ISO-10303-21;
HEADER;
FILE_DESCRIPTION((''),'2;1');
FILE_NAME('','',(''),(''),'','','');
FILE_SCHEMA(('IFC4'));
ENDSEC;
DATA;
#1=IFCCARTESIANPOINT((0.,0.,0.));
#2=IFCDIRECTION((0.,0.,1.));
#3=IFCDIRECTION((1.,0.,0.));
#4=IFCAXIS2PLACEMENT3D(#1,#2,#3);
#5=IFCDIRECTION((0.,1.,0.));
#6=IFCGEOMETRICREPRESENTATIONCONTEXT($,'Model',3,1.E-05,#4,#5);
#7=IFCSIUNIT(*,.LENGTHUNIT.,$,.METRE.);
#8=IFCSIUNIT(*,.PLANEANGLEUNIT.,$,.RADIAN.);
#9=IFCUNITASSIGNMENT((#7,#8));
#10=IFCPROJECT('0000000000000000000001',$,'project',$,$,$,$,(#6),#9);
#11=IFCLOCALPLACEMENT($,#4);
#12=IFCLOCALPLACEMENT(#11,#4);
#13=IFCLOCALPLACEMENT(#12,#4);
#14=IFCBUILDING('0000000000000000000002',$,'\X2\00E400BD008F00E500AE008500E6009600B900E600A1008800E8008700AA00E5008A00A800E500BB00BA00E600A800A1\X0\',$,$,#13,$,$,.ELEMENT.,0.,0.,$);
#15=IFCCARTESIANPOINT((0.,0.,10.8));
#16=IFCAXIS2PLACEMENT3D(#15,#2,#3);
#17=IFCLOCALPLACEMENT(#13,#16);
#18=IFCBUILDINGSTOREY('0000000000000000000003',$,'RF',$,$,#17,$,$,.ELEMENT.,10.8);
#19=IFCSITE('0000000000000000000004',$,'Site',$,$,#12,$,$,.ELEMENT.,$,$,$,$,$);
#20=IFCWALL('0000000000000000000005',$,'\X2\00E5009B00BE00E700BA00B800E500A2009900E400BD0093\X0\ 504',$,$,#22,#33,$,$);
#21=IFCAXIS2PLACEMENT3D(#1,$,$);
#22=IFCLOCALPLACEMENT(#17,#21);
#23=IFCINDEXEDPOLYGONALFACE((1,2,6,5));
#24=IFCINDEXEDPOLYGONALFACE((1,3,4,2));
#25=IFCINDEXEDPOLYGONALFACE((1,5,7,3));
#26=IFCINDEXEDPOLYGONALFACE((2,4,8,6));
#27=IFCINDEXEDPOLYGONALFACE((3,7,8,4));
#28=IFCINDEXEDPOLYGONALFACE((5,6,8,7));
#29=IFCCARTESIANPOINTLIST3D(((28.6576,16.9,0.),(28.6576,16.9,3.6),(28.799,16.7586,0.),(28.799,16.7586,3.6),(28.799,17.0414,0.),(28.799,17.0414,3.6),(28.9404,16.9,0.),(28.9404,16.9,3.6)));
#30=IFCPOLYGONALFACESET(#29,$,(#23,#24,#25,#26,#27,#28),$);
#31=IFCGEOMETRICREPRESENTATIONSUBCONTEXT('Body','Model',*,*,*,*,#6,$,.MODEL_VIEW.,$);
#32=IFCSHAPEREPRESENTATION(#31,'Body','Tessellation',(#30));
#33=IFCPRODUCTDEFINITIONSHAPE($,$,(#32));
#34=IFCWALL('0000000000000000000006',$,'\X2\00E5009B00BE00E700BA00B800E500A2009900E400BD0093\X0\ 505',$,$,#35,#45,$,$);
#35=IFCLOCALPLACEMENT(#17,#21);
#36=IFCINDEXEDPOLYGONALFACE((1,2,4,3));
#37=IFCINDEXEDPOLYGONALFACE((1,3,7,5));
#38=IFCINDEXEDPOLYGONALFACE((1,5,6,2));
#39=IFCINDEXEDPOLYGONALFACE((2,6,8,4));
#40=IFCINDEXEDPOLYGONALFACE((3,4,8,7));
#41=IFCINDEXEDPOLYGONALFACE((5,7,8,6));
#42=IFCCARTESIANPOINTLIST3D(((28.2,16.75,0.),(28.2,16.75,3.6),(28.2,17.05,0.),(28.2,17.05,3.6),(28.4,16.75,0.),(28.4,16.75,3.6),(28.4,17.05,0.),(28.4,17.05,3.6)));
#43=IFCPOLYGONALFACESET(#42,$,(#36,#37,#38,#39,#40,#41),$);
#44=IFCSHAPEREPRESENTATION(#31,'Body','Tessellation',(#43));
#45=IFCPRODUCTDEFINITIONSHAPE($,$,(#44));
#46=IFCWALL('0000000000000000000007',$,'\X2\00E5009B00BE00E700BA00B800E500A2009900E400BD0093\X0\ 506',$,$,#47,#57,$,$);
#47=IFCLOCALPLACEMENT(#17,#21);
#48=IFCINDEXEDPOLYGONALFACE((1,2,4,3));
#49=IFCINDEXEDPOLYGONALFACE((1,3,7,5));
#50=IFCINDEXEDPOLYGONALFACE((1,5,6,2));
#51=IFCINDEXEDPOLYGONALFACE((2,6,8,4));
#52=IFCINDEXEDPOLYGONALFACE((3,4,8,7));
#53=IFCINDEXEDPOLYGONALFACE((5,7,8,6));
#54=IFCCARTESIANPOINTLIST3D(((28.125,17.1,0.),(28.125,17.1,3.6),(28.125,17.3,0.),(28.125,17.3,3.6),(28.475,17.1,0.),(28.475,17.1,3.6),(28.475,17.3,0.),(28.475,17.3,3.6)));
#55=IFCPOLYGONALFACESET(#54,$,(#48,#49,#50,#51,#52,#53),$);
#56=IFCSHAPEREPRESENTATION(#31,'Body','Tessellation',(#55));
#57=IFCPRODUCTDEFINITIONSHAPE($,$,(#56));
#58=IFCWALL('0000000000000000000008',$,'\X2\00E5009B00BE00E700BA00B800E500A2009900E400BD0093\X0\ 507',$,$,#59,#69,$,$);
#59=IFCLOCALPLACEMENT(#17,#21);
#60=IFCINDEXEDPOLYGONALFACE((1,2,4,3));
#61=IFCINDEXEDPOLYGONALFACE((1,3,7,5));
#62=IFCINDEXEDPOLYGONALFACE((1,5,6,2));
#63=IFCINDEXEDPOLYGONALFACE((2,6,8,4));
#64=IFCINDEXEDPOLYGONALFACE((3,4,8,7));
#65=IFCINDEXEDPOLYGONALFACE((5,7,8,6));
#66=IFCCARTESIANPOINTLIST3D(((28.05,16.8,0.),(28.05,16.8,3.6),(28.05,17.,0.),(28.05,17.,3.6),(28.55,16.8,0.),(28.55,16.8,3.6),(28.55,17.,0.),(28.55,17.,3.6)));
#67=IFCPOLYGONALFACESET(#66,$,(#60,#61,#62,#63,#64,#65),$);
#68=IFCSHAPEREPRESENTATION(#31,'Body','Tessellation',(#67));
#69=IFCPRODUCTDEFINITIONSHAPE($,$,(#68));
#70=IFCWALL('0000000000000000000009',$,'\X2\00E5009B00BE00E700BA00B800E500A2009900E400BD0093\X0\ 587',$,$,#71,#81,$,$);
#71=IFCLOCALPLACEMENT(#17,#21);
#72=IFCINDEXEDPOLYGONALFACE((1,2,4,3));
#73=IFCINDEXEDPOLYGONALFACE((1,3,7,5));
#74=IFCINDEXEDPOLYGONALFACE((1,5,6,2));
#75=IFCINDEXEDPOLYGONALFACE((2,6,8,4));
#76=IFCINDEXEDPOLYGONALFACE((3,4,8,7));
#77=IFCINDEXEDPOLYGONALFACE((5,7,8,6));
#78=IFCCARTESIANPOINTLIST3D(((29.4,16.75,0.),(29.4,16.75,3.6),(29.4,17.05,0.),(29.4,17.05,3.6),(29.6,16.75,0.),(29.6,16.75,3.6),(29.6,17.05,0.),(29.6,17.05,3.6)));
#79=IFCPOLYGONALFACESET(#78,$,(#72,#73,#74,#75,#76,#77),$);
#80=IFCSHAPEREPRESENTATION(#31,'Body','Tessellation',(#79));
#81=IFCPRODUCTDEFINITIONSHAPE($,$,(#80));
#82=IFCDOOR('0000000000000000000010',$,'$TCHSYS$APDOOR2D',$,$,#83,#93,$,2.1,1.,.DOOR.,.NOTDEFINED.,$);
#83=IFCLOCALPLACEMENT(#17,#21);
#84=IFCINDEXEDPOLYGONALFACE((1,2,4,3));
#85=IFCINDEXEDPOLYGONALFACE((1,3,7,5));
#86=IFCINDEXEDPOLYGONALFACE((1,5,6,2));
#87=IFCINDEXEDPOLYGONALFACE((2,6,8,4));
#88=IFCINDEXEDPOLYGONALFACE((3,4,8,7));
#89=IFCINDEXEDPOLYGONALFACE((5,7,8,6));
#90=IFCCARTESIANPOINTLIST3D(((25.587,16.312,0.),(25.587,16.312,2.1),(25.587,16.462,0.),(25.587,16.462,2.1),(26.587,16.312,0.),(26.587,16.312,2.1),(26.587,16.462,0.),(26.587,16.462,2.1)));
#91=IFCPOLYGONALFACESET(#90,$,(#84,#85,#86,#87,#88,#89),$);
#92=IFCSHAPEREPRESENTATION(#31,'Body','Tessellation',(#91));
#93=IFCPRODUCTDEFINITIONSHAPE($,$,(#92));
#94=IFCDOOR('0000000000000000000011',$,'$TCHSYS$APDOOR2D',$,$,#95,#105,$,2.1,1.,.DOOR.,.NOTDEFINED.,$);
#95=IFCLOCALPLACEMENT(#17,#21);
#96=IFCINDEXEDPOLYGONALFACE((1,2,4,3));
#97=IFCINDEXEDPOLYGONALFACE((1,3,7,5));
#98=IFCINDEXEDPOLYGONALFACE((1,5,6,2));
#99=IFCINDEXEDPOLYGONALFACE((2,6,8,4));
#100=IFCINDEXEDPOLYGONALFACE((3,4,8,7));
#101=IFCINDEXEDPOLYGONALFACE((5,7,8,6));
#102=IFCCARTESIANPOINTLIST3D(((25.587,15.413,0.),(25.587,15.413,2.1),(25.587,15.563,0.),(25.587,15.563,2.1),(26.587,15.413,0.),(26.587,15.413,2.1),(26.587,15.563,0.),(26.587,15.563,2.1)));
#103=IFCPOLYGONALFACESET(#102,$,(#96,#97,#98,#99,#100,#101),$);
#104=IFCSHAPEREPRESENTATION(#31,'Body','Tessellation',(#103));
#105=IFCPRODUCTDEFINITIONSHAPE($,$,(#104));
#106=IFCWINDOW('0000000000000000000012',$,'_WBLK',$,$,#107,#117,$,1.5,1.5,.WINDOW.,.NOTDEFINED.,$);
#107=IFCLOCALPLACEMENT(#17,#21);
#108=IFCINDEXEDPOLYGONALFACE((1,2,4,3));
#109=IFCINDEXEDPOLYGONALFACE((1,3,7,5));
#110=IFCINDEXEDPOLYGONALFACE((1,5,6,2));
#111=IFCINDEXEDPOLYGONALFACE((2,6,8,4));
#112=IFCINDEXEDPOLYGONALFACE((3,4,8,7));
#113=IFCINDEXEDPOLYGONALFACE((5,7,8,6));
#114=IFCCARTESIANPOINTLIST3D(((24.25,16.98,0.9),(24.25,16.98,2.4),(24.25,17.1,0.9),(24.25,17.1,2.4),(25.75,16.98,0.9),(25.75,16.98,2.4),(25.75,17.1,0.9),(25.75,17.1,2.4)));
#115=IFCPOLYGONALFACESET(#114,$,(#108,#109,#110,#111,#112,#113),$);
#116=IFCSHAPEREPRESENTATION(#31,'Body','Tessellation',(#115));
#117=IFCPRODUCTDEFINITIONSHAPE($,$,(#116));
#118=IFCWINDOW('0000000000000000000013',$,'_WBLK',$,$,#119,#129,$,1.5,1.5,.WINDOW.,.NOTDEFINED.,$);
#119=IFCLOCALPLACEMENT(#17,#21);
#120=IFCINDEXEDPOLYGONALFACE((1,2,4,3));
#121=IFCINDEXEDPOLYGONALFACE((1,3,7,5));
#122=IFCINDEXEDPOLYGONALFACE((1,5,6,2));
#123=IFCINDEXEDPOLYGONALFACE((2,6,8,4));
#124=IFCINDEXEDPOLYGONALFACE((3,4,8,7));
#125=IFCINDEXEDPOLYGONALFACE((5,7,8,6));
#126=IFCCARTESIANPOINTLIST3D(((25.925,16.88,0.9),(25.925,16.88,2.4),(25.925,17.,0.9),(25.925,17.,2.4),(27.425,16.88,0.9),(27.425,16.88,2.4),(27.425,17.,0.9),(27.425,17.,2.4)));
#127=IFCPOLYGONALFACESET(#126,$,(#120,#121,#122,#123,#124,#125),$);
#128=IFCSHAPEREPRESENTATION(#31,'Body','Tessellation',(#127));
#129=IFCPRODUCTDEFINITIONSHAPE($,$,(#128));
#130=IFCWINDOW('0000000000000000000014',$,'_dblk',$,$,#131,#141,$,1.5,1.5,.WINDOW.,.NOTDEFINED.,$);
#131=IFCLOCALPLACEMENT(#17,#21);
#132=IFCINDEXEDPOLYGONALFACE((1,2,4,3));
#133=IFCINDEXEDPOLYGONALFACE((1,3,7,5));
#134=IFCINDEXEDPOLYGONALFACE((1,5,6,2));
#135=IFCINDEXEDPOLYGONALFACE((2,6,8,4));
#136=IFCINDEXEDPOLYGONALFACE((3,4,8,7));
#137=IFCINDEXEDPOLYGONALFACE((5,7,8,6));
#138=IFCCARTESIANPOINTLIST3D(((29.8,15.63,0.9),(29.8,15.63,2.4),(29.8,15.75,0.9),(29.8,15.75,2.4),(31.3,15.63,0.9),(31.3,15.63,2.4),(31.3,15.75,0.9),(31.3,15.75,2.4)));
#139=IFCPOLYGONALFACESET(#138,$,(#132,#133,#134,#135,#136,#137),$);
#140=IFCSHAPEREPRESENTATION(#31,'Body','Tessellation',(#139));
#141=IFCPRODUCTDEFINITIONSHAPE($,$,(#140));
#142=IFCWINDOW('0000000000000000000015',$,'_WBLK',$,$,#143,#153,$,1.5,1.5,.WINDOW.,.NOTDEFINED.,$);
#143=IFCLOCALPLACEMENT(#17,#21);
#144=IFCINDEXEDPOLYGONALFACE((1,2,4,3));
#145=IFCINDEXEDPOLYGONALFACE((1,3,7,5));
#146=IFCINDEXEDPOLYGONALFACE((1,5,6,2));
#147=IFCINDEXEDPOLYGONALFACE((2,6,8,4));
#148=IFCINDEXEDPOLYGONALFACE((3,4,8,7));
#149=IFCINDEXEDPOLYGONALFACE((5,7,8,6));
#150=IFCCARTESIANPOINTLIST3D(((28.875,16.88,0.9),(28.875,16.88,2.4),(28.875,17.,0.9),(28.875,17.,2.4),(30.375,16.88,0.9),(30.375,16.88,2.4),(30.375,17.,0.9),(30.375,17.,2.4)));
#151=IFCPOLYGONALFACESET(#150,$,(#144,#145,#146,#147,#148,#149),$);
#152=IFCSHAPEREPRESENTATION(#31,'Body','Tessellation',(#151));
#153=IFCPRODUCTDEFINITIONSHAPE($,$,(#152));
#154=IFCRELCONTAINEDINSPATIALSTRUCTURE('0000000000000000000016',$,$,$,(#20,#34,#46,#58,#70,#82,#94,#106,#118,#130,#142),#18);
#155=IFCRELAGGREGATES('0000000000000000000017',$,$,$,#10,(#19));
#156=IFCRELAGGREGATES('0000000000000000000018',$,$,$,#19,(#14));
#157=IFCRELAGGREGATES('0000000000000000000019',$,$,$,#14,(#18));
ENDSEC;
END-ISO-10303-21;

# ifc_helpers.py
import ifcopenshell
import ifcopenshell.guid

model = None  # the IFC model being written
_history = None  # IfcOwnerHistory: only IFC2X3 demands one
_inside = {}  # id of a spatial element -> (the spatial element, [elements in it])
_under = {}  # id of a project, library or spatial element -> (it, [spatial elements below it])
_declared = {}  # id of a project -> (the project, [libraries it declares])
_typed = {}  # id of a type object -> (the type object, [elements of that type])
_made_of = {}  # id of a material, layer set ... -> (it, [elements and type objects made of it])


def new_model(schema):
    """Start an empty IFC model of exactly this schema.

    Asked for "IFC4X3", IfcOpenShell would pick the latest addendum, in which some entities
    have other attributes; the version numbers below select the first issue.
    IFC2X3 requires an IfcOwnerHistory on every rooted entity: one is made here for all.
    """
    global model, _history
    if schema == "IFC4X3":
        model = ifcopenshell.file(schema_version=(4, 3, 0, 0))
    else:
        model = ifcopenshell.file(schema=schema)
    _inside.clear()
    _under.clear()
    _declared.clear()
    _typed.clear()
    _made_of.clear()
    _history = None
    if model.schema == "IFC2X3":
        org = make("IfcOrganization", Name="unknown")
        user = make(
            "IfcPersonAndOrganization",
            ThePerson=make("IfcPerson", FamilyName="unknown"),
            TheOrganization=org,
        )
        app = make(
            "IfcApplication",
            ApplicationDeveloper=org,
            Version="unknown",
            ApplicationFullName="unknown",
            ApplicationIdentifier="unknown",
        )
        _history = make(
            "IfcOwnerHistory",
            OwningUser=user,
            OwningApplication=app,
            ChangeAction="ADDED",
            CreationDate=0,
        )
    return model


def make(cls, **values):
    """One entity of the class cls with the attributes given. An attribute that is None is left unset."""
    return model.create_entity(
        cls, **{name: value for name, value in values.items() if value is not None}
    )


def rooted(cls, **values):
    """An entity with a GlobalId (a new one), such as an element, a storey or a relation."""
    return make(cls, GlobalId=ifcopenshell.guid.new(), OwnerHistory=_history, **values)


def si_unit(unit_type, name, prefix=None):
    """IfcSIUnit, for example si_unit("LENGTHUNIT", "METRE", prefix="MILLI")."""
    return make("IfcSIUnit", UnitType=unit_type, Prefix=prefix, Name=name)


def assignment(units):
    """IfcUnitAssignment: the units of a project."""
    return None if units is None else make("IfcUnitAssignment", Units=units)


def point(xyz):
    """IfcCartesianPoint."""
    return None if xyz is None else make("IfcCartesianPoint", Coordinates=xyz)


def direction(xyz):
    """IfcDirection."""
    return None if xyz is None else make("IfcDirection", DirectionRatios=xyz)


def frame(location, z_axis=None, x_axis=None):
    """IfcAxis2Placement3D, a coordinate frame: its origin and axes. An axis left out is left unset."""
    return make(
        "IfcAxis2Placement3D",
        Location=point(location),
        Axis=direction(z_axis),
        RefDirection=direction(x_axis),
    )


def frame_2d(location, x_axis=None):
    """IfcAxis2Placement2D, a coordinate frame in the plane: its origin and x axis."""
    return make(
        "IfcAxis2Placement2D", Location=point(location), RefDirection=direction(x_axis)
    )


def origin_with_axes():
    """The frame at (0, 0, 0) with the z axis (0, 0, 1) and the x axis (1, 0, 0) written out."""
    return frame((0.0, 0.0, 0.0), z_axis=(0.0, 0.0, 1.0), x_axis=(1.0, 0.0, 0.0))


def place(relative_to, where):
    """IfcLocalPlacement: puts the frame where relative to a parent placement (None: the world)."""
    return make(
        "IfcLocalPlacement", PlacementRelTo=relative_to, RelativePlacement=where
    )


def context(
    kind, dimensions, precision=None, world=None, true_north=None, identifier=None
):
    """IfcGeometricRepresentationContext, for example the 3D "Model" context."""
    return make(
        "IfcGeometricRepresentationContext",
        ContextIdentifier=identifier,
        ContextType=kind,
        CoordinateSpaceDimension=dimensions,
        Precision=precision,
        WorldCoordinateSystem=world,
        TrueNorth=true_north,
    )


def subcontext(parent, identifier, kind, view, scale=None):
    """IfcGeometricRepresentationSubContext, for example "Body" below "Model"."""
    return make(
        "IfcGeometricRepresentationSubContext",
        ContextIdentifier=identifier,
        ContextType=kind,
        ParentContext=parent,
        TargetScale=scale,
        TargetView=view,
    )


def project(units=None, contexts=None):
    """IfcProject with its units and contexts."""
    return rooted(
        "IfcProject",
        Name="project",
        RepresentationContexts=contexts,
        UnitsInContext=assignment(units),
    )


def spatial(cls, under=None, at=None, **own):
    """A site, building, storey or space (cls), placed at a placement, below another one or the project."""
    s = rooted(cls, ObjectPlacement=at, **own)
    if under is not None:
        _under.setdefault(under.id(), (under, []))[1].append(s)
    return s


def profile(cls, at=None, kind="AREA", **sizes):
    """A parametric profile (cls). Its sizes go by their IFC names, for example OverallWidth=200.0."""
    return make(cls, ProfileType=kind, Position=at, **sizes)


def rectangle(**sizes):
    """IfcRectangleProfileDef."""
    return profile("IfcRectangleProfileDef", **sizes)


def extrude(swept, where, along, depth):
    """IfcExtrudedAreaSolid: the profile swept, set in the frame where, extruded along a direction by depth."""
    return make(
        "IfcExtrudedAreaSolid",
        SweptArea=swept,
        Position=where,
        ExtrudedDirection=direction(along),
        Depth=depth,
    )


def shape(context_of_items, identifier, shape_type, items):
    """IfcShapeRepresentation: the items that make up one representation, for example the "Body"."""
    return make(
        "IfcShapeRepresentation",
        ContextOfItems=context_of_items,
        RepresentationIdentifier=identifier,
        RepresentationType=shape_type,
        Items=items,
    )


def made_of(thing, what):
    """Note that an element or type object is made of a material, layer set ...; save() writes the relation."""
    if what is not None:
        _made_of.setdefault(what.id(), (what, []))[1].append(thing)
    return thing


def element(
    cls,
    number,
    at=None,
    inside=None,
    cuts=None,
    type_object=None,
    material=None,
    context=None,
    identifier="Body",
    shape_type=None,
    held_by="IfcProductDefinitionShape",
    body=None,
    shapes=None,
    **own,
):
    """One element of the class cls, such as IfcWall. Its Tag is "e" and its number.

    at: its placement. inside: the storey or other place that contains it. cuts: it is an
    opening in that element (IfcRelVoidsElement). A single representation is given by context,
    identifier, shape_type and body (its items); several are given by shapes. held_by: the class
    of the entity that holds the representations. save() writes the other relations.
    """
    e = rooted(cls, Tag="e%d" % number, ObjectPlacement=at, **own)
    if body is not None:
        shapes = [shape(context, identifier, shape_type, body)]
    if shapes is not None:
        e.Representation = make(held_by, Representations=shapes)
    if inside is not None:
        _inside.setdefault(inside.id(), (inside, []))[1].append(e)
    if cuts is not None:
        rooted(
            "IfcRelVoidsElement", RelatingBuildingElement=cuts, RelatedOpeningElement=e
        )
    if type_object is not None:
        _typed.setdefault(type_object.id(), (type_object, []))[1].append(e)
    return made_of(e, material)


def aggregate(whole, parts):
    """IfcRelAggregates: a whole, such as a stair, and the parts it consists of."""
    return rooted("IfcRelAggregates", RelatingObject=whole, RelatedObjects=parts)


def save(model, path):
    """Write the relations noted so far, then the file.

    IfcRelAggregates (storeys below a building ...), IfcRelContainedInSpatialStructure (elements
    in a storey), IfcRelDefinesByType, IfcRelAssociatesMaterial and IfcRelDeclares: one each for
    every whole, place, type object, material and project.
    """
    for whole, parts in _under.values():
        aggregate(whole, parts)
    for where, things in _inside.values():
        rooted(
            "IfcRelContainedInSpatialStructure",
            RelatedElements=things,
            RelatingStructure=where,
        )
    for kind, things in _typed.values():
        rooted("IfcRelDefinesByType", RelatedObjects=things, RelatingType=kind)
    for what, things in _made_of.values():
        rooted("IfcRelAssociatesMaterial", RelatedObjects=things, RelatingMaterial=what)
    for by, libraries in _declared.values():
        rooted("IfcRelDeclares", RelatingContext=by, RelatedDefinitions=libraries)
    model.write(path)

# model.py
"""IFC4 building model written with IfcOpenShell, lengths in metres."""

from ifc_helpers import new_model, si_unit, direction, frame, frame_2d, origin_with_axes, place, context, subcontext, project, spatial, rectangle, extrude, element, save


model = new_model("IFC4")

# Units and contexts
model_context = context("Model", 3, precision=1e-05, world=origin_with_axes(), true_north=direction((0.0, 1.0, 0.0)))
body_context = subcontext(model_context, "Body", "Model", "MODEL_VIEW")
ifc_project = project(units=[si_unit("LENGTHUNIT", "METRE"), si_unit("PLANEANGLEUNIT", "RADIAN")], contexts=[model_context])

# Site, building, storey
placement = place(None, origin_with_axes())
site_placement = place(placement, origin_with_axes())
site = spatial("IfcSite", under=ifc_project, at=site_placement, Name="Site", CompositionType="ELEMENT")
building_placement = place(site_placement, origin_with_axes())
building = spatial("IfcBuilding", under=site, at=building_placement, Name="ä½\u008få®\u0085æ\u0096¹æ¡\u0088è\u0087ªå\u008a¨å»ºæ¨¡", CompositionType="ELEMENT", ElevationOfRefHeight=0.0, ElevationOfTerrain=0.0)
storey_placement = place(building_placement, frame((0.0, 0.0, 10.8), z_axis=(0.0, 0.0, 1.0), x_axis=(1.0, 0.0, 0.0)))
storey = spatial("IfcBuildingStorey", under=building, at=storey_placement, Name="RF", CompositionType="ELEMENT", Elevation=10.8)

# Walls
for number, where, z_axis, x_axis, name in (
    (1, (28.799, 16.9, 0.0), (0.0, 0.0, 1.0), (0.707107, -0.707107, 0.0), "å\u009b¾çº¸å¢\u0099ä½\u0093 504"),
):
    element("IfcWall", number, at=place(storey_placement, frame(where, z_axis=z_axis, x_axis=x_axis)), inside=storey, Name=name, context=body_context, shape_type="SweptSolid", body=[
        extrude(rectangle(XDim=0.2, YDim=0.2, at=frame_2d((0.0, 0.0), x_axis=(1.0, 0.0, 0.0))), frame((0.0, 0.0, 0.0), z_axis=(0.0, 0.0, 1.0)), (0.0, 0.0, 1.0), 3.6),
    ])
wall_1_placement = place(storey_placement, frame((28.3, 16.9, 0.0), z_axis=(0.0, 0.0, 1.0), x_axis=(0.0, 1.0, 0.0)))
element("IfcWall", 2, at=wall_1_placement, inside=storey, Name="å\u009b¾çº¸å¢\u0099ä½\u0093 505", context=body_context, shape_type="SweptSolid", body=[
    extrude(rectangle(XDim=0.3, YDim=0.2, at=frame_2d((0.0, 0.0), x_axis=(1.0, 0.0, 0.0))), frame((0.0, 0.0, 0.0), z_axis=(0.0, 0.0, 1.0)), (0.0, 0.0, 1.0), 3.6),
])
wall_2_placement = place(storey_placement, frame((28.3, 17.2, 0.0), z_axis=(0.0, 0.0, 1.0), x_axis=(1.0, 0.0, 0.0)))
element("IfcWall", 3, at=wall_2_placement, inside=storey, Name="å\u009b¾çº¸å¢\u0099ä½\u0093 506", context=body_context, shape_type="SweptSolid", body=[
    extrude(rectangle(XDim=0.35, YDim=0.2, at=frame_2d((0.0, 0.0), x_axis=(1.0, 0.0, 0.0))), frame((0.0, 0.0, 0.0), z_axis=(0.0, 0.0, 1.0)), (0.0, 0.0, 1.0), 3.6),
])
wall_3_placement = place(storey_placement, frame((28.3, 16.9, 0.0), z_axis=(0.0, 0.0, 1.0), x_axis=(1.0, 0.0, 0.0)))
element("IfcWall", 4, at=wall_3_placement, inside=storey, Name="å\u009b¾çº¸å¢\u0099ä½\u0093 507", context=body_context, shape_type="SweptSolid", body=[
    extrude(rectangle(XDim=0.5, YDim=0.2, at=frame_2d((0.0, 0.0), x_axis=(1.0, 0.0, 0.0))), frame((0.0, 0.0, 0.0), z_axis=(0.0, 0.0, 1.0)), (0.0, 0.0, 1.0), 3.6),
])
wall_4_placement = place(storey_placement, frame((29.5, 16.9, 0.0), z_axis=(0.0, 0.0, 1.0), x_axis=(0.0, 1.0, 0.0)))
element("IfcWall", 5, at=wall_4_placement, inside=storey, Name="å\u009b¾çº¸å¢\u0099ä½\u0093 587", context=body_context, shape_type="SweptSolid", body=[
    extrude(rectangle(XDim=0.3, YDim=0.2, at=frame_2d((0.0, 0.0), x_axis=(1.0, 0.0, 0.0))), frame((0.0, 0.0, 0.0), z_axis=(0.0, 0.0, 1.0)), (0.0, 0.0, 1.0), 3.6),
])

# Doors
for number, where, z_axis, x_axis, name in (
    (6, (26.087, 16.387, 0.0), (0.0, 0.0, 1.0), (1.0, 0.0, 0.0), "$TCHSYS$APDOOR2D"),
    (7, (26.087, 15.488, 0.0), (0.0, 0.0, 1.0), (1.0, 0.0, 0.0), "$TCHSYS$APDOOR2D"),
):
    element("IfcDoor", number, at=place(storey_placement, frame(where, z_axis=z_axis, x_axis=x_axis)), inside=storey, Name=name, OperationType="NOTDEFINED", OverallHeight=2.1, OverallWidth=1.0, PredefinedType="DOOR", context=body_context, shape_type="SweptSolid", body=[
        extrude(rectangle(XDim=1.0, YDim=0.15, at=frame_2d((0.0, 0.0), x_axis=(1.0, 0.0, 0.0))), frame((0.0, 0.0, 0.0), z_axis=(0.0, 0.0, 1.0)), (0.0, 0.0, 1.0), 2.1),
    ])

# Windows
for number, where, z_axis, x_axis, name in (
    (8, (25.0, 17.04, 0.9), (0.0, 0.0, 1.0), (1.0, 0.0, 0.0), "_WBLK"),
    (9, (26.675, 16.94, 0.9), (0.0, 0.0, 1.0), (1.0, 0.0, 0.0), "_WBLK"),
    (10, (30.55, 15.69, 0.9), (0.0, 0.0, 1.0), (1.0, 0.0, 0.0), "_dblk"),
    (11, (29.625, 16.94, 0.9), (0.0, 0.0, 1.0), (1.0, 0.0, 0.0), "_WBLK"),
):
    element("IfcWindow", number, at=place(storey_placement, frame(where, z_axis=z_axis, x_axis=x_axis)), inside=storey, Name=name, OverallHeight=1.5, OverallWidth=1.5, PartitioningType="NOTDEFINED", PredefinedType="WINDOW", context=body_context, shape_type="SweptSolid", body=[
        extrude(rectangle(XDim=1.5, YDim=0.12, at=frame_2d((0.0, 0.0), x_axis=(1.0, 0.0, 0.0))), frame((0.0, 0.0, 0.0), z_axis=(0.0, 0.0, 1.0)), (0.0, 0.0, 1.0), 1.5),
    ])

save(model, "model.ifc")
